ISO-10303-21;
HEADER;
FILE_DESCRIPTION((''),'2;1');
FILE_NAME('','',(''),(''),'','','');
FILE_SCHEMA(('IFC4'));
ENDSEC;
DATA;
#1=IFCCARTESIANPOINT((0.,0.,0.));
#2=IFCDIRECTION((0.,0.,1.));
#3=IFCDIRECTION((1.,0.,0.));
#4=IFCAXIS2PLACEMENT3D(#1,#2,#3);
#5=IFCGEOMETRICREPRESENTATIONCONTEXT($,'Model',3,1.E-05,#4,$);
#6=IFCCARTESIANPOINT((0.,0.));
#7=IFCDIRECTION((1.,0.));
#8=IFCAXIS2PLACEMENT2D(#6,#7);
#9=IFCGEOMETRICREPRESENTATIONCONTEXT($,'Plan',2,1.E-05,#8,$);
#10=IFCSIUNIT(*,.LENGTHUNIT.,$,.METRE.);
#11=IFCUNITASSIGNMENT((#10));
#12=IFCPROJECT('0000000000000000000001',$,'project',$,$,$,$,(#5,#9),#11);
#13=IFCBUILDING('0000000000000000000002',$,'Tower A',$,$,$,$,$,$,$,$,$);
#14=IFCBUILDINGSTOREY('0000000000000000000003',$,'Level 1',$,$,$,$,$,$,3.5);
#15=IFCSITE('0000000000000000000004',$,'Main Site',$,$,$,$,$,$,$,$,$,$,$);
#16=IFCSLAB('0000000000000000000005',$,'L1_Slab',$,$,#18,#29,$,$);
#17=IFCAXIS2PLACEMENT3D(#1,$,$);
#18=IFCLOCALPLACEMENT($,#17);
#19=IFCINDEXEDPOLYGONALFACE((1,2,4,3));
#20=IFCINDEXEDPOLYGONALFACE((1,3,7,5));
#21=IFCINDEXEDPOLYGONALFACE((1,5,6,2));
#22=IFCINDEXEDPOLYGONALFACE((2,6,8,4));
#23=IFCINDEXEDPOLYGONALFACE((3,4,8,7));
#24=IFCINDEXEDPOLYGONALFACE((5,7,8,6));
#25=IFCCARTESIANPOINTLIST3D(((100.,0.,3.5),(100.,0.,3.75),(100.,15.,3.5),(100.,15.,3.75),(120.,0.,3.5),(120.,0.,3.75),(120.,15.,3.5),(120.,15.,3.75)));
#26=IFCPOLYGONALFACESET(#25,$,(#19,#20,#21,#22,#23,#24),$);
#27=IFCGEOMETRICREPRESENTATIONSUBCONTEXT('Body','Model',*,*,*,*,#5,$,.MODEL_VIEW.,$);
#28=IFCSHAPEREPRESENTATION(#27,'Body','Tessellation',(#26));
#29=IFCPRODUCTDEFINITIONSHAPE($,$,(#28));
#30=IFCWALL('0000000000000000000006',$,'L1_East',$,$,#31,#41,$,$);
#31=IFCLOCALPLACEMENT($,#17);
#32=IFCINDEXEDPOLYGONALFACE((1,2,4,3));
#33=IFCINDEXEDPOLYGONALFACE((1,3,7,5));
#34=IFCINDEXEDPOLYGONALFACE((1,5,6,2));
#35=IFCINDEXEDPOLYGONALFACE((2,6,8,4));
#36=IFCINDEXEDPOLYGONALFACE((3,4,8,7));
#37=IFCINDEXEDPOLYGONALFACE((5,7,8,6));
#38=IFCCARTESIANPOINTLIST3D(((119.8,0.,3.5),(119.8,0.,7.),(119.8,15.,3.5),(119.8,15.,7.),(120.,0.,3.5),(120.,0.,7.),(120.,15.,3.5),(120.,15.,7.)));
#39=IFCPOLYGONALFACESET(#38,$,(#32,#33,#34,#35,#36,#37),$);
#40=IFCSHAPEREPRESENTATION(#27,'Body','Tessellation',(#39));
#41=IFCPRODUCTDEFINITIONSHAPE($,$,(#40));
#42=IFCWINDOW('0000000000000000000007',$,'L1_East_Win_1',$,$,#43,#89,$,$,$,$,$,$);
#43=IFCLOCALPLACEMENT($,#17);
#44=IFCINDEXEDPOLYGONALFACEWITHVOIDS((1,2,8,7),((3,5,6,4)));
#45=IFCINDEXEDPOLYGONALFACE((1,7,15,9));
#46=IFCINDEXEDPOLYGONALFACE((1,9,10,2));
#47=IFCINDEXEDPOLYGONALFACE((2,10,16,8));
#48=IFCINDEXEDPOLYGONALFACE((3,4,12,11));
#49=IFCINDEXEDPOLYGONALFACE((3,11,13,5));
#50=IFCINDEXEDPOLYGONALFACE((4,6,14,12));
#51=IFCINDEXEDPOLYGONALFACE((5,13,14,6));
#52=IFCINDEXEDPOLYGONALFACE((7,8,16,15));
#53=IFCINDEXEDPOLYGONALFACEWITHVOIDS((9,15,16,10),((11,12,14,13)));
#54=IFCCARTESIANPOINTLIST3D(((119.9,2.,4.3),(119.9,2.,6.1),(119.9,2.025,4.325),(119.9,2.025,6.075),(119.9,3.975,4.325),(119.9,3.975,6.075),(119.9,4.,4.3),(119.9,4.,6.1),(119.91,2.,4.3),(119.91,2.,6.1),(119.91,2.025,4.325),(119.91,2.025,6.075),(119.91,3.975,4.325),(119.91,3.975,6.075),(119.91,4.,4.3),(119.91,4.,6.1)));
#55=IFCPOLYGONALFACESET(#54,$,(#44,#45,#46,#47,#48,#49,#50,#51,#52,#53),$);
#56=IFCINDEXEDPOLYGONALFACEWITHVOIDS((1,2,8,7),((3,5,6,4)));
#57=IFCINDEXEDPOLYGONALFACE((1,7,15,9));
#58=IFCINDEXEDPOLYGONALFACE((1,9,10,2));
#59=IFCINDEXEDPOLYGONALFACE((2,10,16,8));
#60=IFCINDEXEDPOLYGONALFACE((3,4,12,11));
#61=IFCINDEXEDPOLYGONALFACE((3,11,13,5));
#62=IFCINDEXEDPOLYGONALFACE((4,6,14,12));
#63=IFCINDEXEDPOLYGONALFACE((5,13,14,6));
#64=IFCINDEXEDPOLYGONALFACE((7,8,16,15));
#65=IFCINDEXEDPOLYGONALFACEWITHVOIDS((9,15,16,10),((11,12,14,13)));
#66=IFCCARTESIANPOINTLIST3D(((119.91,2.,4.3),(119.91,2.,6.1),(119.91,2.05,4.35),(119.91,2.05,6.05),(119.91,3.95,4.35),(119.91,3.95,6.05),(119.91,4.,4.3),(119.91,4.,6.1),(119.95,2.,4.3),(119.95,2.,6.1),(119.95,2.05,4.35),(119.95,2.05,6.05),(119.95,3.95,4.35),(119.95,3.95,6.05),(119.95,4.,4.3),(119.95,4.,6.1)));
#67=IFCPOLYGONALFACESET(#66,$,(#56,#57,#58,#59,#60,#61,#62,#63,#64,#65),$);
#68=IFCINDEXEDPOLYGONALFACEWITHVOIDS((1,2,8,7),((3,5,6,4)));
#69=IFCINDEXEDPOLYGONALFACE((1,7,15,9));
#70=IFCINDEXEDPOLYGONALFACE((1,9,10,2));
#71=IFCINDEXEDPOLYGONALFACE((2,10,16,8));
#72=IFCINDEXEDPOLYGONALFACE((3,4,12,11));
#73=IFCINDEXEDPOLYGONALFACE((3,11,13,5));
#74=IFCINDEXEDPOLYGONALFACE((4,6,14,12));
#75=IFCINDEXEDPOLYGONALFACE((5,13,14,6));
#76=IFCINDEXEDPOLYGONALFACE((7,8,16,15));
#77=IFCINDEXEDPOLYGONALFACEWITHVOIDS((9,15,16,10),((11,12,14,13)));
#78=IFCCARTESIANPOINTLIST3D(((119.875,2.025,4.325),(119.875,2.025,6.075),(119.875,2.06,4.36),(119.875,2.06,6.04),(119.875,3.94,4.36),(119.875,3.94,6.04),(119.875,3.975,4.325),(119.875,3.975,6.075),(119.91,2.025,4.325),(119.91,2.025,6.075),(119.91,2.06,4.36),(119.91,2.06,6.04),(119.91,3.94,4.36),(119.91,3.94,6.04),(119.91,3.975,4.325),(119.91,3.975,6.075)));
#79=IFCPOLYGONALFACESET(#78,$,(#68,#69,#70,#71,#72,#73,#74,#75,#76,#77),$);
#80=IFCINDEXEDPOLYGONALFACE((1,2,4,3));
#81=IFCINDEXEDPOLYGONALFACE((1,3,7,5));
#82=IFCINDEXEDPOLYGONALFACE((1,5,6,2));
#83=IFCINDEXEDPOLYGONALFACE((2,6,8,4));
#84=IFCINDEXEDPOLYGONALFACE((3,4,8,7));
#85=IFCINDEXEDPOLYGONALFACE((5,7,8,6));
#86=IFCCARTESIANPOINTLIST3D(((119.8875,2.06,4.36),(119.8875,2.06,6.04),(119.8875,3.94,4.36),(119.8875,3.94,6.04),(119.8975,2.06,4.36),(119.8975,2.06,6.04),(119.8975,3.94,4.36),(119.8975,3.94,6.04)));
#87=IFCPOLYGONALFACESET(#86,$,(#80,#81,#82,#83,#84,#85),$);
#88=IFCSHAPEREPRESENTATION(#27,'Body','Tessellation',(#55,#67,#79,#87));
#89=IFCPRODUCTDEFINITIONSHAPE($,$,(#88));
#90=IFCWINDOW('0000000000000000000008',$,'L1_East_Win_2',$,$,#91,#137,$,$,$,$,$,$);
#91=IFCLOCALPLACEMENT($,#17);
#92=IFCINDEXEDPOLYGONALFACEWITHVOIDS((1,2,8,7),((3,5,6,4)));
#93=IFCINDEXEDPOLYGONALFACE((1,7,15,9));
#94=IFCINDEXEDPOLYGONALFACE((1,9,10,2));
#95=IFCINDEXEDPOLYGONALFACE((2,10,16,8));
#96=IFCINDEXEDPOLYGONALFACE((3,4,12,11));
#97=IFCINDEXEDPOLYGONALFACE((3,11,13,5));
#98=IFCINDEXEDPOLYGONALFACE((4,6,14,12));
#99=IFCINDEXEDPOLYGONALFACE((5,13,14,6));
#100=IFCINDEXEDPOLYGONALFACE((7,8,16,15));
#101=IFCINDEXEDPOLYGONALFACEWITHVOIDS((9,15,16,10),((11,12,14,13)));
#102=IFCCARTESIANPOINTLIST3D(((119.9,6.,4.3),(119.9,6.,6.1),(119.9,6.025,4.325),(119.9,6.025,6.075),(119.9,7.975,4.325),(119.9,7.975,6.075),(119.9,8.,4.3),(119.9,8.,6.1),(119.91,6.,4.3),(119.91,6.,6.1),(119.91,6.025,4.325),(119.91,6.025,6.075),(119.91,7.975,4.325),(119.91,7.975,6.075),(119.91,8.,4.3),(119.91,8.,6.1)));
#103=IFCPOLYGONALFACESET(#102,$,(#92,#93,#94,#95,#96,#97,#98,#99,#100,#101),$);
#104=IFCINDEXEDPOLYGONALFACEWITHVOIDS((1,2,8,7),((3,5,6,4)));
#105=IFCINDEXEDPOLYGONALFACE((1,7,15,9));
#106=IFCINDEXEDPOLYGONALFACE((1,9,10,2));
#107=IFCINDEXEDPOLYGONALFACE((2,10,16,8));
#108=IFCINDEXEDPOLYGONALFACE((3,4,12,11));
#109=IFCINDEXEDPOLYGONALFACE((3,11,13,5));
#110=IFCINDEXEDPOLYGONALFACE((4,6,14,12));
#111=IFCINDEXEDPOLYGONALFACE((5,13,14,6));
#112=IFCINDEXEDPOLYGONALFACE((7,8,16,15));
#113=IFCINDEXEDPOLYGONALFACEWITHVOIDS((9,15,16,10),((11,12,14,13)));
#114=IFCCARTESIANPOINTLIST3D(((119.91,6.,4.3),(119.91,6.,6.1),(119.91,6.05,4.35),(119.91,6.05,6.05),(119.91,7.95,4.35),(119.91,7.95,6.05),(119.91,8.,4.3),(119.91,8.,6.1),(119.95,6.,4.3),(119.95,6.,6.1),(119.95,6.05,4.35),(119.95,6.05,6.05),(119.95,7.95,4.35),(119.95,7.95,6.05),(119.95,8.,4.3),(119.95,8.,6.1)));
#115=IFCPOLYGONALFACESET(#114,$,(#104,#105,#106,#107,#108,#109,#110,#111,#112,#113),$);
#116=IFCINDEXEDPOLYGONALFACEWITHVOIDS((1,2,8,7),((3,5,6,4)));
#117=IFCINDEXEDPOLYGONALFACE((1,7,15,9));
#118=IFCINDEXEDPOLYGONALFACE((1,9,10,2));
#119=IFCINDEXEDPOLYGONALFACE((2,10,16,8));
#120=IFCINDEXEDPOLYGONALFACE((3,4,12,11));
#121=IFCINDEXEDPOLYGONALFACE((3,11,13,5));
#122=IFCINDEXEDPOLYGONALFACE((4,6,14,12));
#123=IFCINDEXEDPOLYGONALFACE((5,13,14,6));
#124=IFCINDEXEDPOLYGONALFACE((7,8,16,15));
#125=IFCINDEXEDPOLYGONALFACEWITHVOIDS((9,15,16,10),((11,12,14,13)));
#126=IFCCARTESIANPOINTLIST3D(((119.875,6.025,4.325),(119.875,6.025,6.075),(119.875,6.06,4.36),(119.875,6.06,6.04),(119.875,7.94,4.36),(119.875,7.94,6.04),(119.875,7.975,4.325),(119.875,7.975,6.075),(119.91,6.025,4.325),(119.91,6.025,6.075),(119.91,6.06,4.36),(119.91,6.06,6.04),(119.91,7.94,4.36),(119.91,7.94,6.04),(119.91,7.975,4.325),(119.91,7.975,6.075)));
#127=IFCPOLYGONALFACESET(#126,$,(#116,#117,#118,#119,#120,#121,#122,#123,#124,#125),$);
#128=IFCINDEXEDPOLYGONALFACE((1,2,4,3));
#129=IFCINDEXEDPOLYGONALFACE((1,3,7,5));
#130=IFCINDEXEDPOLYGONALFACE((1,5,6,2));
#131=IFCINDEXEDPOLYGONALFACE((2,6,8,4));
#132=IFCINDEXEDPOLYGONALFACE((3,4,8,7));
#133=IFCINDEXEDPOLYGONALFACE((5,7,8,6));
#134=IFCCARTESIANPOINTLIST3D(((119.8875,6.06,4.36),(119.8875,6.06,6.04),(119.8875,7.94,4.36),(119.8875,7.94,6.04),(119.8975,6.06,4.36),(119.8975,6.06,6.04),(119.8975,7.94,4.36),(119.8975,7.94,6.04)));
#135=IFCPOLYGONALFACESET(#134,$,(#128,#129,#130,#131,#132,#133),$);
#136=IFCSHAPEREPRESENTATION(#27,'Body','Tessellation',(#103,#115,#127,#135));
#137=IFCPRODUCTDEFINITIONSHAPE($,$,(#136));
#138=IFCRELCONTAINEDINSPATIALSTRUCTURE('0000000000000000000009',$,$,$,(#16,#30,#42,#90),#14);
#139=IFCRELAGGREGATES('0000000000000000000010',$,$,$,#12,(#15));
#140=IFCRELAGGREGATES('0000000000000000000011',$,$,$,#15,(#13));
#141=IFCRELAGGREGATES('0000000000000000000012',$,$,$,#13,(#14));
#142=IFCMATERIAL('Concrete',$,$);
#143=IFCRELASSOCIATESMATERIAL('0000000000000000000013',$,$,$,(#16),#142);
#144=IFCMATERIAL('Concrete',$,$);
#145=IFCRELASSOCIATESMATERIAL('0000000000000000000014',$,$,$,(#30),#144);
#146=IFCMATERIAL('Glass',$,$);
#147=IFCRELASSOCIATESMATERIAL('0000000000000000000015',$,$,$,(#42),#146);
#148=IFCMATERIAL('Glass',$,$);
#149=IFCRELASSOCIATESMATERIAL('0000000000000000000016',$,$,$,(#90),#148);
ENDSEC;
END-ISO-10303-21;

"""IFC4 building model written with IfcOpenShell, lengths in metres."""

from ifc_helpers import new_model, si_unit, frame, origin_with_axes, origin_2d_with_axis, place, context, subcontext, project, spatial, line, indexed_curve, outline, extrude, material, element, fill, save


model = new_model("IFC4")

# Units and contexts
model_context = context("Model", 3, precision=1e-05, world=origin_with_axes())
plan_context = context("Plan", 2, precision=1e-05, world=origin_2d_with_axis())
body_context = subcontext(model_context, "Body", "Model", "MODEL_VIEW")
ifc_project = project(units=[si_unit("LENGTHUNIT", "METRE")], contexts=[model_context, plan_context])

# Site, building, storey
site = spatial("IfcSite", under=ifc_project, Name="Main Site")
building = spatial("IfcBuilding", under=site, Name="Tower A")
storey = spatial("IfcBuildingStorey", under=building, Name="Level 1", Elevation=3.5)

# Slab
ifc_material_1 = material(Name="Concrete")
slab_placement = place(None, frame((100.0, 0.0, 3.5), z_axis=(0.0, 0.0, 1.0), x_axis=(1.0, 0.0, 0.0)))
element("IfcSlab", 1, at=slab_placement, inside=storey, material=ifc_material_1, Name="L1_Slab", context=body_context, shape_type="SweptSolid", body=[
    extrude(outline(indexed_curve([(0.0, 0.0), (20.0, 0.0), (20.0, 15.0), (0.0, 15.0)])), None, (0.0, 0.0, 1.0), 0.25),
])

# Wall, openings, windows
ifc_material_2 = material(Name="Concrete")
wall_1_placement = place(None, frame((120.0, 0.0, 3.5), z_axis=(0.0, 0.0, 1.0), x_axis=(0.0, 1.0, 0.0)))
wall_1 = element("IfcWall", 2, at=wall_1_placement, inside=storey, material=ifc_material_2, Name="L1_East", context=body_context, shape_type="SweptSolid", body=[
    extrude(outline(indexed_curve([(0.0, 0.0), (0.0, 0.2), (15.0, 0.2), (15.0, 0.0), (0.0, 0.0)], self_intersect=False)), origin_with_axes(), (0.0, 0.0, 1.0), 3.5),
])
opening_1_placement = place(wall_1_placement, frame((2.0, 0.0, 0.8), z_axis=(0.0, 0.0, 1.0), x_axis=(0.0, -1.0, 0.0)))
opening_1 = element("IfcOpeningElement", 3, at=opening_1_placement, cuts=wall_1, context=body_context, shape_type="SweptSolid", body=[
    extrude(outline(indexed_curve([(0.0, 0.0), (0.0, 0.25), (2.0, 0.25), (2.0, 0.0), (0.0, 0.0)], self_intersect=False)), origin_with_axes(), (0.0, 0.0, 1.0), 1.8),
])
opening_2_placement = place(wall_1_placement, frame((6.0, 0.0, 0.8), z_axis=(0.0, 0.0, 1.0), x_axis=(0.0, -1.0, 0.0)))
opening_2 = element("IfcOpeningElement", 4, at=opening_2_placement, cuts=wall_1, context=body_context, shape_type="SweptSolid", body=[
    extrude(outline(indexed_curve([(0.0, 0.0), (0.0, 0.25), (2.0, 0.25), (2.0, 0.0), (0.0, 0.0)], self_intersect=False)), origin_with_axes(), (0.0, 0.0, 1.0), 1.8),
])
ifc_material_3 = material(Name="Glass")
window_1_placement = place(None, frame((120.0, 2.0, 4.3), z_axis=(0.0, 0.0, 1.0), x_axis=(0.0, 1.0, 0.0)))
window_1 = element("IfcWindow", 5, at=window_1_placement, inside=storey, material=ifc_material_3, Name="L1_East_Win_1", context=body_context, shape_type="SweptSolid", body=[
    extrude(outline(indexed_curve([(0.0, 0.0), (2.0, 0.0), (2.0, 1.8), (0.0, 1.8)], segments=[line(1, 2, 3, 4, 1)]), holes=[indexed_curve([(0.025, 0.025), (1.975, 0.025), (1.975, 1.775), (0.025, 1.775)], segments=[line(1, 2, 3, 4, 1)])]), frame((0.0, 0.09, 0.0), z_axis=(0.0, -1.0, 0.0), x_axis=(1.0, 0.0, 0.0)), (0.0, 0.0, -1.0), 0.01),
    extrude(outline(indexed_curve([(0.0, 0.0), (2.0, 0.0), (2.0, 1.8), (0.0, 1.8)], segments=[line(1, 2, 3, 4, 1)]), holes=[indexed_curve([(0.05, 0.05), (1.95, 0.05), (1.95, 1.75), (0.05, 1.75)], segments=[line(1, 2, 3, 4, 1)])]), frame((0.0, 0.05, 0.0), z_axis=(0.0, -1.0, 0.0), x_axis=(1.0, 0.0, 0.0)), (0.0, 0.0, -1.0), 0.04),
    extrude(outline(indexed_curve([(0.0, 0.0), (1.95, 0.0), (1.95, 1.75), (0.0, 1.75)], segments=[line(1, 2, 3, 4, 1)]), holes=[indexed_curve([(0.035, 0.035), (1.915, 0.035), (1.915, 1.715), (0.035, 1.715)], segments=[line(1, 2, 3, 4, 1)])]), frame((0.025, 0.09, 0.025), z_axis=(0.0, -1.0, 0.0), x_axis=(1.0, 0.0, 0.0)), (0.0, 0.0, -1.0), 0.035),
    extrude(outline(indexed_curve([(0.035, 0.035), (1.915, 0.035), (1.915, 1.715), (0.035, 1.715)], segments=[line(1, 2, 3, 4, 1)])), frame((0.025, 0.1025, 0.025), z_axis=(0.0, -1.0, 0.0), x_axis=(1.0, 0.0, 0.0)), (0.0, 0.0, -1.0), 0.01),
])
fill(opening_1, window_1)
ifc_material_4 = material(Name="Glass")
window_2_placement = place(None, frame((120.0, 6.0, 4.3), z_axis=(0.0, 0.0, 1.0), x_axis=(0.0, 1.0, 0.0)))
window_2 = element("IfcWindow", 6, at=window_2_placement, inside=storey, material=ifc_material_4, Name="L1_East_Win_2", context=body_context, shape_type="SweptSolid", body=[
    extrude(outline(indexed_curve([(0.0, 0.0), (2.0, 0.0), (2.0, 1.8), (0.0, 1.8)], segments=[line(1, 2, 3, 4, 1)]), holes=[indexed_curve([(0.025, 0.025), (1.975, 0.025), (1.975, 1.775), (0.025, 1.775)], segments=[line(1, 2, 3, 4, 1)])]), frame((0.0, 0.09, 0.0), z_axis=(0.0, -1.0, 0.0), x_axis=(1.0, 0.0, 0.0)), (0.0, 0.0, -1.0), 0.01),
    extrude(outline(indexed_curve([(0.0, 0.0), (2.0, 0.0), (2.0, 1.8), (0.0, 1.8)], segments=[line(1, 2, 3, 4, 1)]), holes=[indexed_curve([(0.05, 0.05), (1.95, 0.05), (1.95, 1.75), (0.05, 1.75)], segments=[line(1, 2, 3, 4, 1)])]), frame((0.0, 0.05, 0.0), z_axis=(0.0, -1.0, 0.0), x_axis=(1.0, 0.0, 0.0)), (0.0, 0.0, -1.0), 0.04),
    extrude(outline(indexed_curve([(0.0, 0.0), (1.95, 0.0), (1.95, 1.75), (0.0, 1.75)], segments=[line(1, 2, 3, 4, 1)]), holes=[indexed_curve([(0.035, 0.035), (1.915, 0.035), (1.915, 1.715), (0.035, 1.715)], segments=[line(1, 2, 3, 4, 1)])]), frame((0.025, 0.09, 0.025), z_axis=(0.0, -1.0, 0.0), x_axis=(1.0, 0.0, 0.0)), (0.0, 0.0, -1.0), 0.035),
    extrude(outline(indexed_curve([(0.035, 0.035), (1.915, 0.035), (1.915, 1.715), (0.035, 1.715)], segments=[line(1, 2, 3, 4, 1)])), frame((0.025, 0.1025, 0.025), z_axis=(0.0, -1.0, 0.0), x_axis=(1.0, 0.0, 0.0)), (0.0, 0.0, -1.0), 0.01),
])
fill(opening_2, window_2)

save(model, "model.ifc")
